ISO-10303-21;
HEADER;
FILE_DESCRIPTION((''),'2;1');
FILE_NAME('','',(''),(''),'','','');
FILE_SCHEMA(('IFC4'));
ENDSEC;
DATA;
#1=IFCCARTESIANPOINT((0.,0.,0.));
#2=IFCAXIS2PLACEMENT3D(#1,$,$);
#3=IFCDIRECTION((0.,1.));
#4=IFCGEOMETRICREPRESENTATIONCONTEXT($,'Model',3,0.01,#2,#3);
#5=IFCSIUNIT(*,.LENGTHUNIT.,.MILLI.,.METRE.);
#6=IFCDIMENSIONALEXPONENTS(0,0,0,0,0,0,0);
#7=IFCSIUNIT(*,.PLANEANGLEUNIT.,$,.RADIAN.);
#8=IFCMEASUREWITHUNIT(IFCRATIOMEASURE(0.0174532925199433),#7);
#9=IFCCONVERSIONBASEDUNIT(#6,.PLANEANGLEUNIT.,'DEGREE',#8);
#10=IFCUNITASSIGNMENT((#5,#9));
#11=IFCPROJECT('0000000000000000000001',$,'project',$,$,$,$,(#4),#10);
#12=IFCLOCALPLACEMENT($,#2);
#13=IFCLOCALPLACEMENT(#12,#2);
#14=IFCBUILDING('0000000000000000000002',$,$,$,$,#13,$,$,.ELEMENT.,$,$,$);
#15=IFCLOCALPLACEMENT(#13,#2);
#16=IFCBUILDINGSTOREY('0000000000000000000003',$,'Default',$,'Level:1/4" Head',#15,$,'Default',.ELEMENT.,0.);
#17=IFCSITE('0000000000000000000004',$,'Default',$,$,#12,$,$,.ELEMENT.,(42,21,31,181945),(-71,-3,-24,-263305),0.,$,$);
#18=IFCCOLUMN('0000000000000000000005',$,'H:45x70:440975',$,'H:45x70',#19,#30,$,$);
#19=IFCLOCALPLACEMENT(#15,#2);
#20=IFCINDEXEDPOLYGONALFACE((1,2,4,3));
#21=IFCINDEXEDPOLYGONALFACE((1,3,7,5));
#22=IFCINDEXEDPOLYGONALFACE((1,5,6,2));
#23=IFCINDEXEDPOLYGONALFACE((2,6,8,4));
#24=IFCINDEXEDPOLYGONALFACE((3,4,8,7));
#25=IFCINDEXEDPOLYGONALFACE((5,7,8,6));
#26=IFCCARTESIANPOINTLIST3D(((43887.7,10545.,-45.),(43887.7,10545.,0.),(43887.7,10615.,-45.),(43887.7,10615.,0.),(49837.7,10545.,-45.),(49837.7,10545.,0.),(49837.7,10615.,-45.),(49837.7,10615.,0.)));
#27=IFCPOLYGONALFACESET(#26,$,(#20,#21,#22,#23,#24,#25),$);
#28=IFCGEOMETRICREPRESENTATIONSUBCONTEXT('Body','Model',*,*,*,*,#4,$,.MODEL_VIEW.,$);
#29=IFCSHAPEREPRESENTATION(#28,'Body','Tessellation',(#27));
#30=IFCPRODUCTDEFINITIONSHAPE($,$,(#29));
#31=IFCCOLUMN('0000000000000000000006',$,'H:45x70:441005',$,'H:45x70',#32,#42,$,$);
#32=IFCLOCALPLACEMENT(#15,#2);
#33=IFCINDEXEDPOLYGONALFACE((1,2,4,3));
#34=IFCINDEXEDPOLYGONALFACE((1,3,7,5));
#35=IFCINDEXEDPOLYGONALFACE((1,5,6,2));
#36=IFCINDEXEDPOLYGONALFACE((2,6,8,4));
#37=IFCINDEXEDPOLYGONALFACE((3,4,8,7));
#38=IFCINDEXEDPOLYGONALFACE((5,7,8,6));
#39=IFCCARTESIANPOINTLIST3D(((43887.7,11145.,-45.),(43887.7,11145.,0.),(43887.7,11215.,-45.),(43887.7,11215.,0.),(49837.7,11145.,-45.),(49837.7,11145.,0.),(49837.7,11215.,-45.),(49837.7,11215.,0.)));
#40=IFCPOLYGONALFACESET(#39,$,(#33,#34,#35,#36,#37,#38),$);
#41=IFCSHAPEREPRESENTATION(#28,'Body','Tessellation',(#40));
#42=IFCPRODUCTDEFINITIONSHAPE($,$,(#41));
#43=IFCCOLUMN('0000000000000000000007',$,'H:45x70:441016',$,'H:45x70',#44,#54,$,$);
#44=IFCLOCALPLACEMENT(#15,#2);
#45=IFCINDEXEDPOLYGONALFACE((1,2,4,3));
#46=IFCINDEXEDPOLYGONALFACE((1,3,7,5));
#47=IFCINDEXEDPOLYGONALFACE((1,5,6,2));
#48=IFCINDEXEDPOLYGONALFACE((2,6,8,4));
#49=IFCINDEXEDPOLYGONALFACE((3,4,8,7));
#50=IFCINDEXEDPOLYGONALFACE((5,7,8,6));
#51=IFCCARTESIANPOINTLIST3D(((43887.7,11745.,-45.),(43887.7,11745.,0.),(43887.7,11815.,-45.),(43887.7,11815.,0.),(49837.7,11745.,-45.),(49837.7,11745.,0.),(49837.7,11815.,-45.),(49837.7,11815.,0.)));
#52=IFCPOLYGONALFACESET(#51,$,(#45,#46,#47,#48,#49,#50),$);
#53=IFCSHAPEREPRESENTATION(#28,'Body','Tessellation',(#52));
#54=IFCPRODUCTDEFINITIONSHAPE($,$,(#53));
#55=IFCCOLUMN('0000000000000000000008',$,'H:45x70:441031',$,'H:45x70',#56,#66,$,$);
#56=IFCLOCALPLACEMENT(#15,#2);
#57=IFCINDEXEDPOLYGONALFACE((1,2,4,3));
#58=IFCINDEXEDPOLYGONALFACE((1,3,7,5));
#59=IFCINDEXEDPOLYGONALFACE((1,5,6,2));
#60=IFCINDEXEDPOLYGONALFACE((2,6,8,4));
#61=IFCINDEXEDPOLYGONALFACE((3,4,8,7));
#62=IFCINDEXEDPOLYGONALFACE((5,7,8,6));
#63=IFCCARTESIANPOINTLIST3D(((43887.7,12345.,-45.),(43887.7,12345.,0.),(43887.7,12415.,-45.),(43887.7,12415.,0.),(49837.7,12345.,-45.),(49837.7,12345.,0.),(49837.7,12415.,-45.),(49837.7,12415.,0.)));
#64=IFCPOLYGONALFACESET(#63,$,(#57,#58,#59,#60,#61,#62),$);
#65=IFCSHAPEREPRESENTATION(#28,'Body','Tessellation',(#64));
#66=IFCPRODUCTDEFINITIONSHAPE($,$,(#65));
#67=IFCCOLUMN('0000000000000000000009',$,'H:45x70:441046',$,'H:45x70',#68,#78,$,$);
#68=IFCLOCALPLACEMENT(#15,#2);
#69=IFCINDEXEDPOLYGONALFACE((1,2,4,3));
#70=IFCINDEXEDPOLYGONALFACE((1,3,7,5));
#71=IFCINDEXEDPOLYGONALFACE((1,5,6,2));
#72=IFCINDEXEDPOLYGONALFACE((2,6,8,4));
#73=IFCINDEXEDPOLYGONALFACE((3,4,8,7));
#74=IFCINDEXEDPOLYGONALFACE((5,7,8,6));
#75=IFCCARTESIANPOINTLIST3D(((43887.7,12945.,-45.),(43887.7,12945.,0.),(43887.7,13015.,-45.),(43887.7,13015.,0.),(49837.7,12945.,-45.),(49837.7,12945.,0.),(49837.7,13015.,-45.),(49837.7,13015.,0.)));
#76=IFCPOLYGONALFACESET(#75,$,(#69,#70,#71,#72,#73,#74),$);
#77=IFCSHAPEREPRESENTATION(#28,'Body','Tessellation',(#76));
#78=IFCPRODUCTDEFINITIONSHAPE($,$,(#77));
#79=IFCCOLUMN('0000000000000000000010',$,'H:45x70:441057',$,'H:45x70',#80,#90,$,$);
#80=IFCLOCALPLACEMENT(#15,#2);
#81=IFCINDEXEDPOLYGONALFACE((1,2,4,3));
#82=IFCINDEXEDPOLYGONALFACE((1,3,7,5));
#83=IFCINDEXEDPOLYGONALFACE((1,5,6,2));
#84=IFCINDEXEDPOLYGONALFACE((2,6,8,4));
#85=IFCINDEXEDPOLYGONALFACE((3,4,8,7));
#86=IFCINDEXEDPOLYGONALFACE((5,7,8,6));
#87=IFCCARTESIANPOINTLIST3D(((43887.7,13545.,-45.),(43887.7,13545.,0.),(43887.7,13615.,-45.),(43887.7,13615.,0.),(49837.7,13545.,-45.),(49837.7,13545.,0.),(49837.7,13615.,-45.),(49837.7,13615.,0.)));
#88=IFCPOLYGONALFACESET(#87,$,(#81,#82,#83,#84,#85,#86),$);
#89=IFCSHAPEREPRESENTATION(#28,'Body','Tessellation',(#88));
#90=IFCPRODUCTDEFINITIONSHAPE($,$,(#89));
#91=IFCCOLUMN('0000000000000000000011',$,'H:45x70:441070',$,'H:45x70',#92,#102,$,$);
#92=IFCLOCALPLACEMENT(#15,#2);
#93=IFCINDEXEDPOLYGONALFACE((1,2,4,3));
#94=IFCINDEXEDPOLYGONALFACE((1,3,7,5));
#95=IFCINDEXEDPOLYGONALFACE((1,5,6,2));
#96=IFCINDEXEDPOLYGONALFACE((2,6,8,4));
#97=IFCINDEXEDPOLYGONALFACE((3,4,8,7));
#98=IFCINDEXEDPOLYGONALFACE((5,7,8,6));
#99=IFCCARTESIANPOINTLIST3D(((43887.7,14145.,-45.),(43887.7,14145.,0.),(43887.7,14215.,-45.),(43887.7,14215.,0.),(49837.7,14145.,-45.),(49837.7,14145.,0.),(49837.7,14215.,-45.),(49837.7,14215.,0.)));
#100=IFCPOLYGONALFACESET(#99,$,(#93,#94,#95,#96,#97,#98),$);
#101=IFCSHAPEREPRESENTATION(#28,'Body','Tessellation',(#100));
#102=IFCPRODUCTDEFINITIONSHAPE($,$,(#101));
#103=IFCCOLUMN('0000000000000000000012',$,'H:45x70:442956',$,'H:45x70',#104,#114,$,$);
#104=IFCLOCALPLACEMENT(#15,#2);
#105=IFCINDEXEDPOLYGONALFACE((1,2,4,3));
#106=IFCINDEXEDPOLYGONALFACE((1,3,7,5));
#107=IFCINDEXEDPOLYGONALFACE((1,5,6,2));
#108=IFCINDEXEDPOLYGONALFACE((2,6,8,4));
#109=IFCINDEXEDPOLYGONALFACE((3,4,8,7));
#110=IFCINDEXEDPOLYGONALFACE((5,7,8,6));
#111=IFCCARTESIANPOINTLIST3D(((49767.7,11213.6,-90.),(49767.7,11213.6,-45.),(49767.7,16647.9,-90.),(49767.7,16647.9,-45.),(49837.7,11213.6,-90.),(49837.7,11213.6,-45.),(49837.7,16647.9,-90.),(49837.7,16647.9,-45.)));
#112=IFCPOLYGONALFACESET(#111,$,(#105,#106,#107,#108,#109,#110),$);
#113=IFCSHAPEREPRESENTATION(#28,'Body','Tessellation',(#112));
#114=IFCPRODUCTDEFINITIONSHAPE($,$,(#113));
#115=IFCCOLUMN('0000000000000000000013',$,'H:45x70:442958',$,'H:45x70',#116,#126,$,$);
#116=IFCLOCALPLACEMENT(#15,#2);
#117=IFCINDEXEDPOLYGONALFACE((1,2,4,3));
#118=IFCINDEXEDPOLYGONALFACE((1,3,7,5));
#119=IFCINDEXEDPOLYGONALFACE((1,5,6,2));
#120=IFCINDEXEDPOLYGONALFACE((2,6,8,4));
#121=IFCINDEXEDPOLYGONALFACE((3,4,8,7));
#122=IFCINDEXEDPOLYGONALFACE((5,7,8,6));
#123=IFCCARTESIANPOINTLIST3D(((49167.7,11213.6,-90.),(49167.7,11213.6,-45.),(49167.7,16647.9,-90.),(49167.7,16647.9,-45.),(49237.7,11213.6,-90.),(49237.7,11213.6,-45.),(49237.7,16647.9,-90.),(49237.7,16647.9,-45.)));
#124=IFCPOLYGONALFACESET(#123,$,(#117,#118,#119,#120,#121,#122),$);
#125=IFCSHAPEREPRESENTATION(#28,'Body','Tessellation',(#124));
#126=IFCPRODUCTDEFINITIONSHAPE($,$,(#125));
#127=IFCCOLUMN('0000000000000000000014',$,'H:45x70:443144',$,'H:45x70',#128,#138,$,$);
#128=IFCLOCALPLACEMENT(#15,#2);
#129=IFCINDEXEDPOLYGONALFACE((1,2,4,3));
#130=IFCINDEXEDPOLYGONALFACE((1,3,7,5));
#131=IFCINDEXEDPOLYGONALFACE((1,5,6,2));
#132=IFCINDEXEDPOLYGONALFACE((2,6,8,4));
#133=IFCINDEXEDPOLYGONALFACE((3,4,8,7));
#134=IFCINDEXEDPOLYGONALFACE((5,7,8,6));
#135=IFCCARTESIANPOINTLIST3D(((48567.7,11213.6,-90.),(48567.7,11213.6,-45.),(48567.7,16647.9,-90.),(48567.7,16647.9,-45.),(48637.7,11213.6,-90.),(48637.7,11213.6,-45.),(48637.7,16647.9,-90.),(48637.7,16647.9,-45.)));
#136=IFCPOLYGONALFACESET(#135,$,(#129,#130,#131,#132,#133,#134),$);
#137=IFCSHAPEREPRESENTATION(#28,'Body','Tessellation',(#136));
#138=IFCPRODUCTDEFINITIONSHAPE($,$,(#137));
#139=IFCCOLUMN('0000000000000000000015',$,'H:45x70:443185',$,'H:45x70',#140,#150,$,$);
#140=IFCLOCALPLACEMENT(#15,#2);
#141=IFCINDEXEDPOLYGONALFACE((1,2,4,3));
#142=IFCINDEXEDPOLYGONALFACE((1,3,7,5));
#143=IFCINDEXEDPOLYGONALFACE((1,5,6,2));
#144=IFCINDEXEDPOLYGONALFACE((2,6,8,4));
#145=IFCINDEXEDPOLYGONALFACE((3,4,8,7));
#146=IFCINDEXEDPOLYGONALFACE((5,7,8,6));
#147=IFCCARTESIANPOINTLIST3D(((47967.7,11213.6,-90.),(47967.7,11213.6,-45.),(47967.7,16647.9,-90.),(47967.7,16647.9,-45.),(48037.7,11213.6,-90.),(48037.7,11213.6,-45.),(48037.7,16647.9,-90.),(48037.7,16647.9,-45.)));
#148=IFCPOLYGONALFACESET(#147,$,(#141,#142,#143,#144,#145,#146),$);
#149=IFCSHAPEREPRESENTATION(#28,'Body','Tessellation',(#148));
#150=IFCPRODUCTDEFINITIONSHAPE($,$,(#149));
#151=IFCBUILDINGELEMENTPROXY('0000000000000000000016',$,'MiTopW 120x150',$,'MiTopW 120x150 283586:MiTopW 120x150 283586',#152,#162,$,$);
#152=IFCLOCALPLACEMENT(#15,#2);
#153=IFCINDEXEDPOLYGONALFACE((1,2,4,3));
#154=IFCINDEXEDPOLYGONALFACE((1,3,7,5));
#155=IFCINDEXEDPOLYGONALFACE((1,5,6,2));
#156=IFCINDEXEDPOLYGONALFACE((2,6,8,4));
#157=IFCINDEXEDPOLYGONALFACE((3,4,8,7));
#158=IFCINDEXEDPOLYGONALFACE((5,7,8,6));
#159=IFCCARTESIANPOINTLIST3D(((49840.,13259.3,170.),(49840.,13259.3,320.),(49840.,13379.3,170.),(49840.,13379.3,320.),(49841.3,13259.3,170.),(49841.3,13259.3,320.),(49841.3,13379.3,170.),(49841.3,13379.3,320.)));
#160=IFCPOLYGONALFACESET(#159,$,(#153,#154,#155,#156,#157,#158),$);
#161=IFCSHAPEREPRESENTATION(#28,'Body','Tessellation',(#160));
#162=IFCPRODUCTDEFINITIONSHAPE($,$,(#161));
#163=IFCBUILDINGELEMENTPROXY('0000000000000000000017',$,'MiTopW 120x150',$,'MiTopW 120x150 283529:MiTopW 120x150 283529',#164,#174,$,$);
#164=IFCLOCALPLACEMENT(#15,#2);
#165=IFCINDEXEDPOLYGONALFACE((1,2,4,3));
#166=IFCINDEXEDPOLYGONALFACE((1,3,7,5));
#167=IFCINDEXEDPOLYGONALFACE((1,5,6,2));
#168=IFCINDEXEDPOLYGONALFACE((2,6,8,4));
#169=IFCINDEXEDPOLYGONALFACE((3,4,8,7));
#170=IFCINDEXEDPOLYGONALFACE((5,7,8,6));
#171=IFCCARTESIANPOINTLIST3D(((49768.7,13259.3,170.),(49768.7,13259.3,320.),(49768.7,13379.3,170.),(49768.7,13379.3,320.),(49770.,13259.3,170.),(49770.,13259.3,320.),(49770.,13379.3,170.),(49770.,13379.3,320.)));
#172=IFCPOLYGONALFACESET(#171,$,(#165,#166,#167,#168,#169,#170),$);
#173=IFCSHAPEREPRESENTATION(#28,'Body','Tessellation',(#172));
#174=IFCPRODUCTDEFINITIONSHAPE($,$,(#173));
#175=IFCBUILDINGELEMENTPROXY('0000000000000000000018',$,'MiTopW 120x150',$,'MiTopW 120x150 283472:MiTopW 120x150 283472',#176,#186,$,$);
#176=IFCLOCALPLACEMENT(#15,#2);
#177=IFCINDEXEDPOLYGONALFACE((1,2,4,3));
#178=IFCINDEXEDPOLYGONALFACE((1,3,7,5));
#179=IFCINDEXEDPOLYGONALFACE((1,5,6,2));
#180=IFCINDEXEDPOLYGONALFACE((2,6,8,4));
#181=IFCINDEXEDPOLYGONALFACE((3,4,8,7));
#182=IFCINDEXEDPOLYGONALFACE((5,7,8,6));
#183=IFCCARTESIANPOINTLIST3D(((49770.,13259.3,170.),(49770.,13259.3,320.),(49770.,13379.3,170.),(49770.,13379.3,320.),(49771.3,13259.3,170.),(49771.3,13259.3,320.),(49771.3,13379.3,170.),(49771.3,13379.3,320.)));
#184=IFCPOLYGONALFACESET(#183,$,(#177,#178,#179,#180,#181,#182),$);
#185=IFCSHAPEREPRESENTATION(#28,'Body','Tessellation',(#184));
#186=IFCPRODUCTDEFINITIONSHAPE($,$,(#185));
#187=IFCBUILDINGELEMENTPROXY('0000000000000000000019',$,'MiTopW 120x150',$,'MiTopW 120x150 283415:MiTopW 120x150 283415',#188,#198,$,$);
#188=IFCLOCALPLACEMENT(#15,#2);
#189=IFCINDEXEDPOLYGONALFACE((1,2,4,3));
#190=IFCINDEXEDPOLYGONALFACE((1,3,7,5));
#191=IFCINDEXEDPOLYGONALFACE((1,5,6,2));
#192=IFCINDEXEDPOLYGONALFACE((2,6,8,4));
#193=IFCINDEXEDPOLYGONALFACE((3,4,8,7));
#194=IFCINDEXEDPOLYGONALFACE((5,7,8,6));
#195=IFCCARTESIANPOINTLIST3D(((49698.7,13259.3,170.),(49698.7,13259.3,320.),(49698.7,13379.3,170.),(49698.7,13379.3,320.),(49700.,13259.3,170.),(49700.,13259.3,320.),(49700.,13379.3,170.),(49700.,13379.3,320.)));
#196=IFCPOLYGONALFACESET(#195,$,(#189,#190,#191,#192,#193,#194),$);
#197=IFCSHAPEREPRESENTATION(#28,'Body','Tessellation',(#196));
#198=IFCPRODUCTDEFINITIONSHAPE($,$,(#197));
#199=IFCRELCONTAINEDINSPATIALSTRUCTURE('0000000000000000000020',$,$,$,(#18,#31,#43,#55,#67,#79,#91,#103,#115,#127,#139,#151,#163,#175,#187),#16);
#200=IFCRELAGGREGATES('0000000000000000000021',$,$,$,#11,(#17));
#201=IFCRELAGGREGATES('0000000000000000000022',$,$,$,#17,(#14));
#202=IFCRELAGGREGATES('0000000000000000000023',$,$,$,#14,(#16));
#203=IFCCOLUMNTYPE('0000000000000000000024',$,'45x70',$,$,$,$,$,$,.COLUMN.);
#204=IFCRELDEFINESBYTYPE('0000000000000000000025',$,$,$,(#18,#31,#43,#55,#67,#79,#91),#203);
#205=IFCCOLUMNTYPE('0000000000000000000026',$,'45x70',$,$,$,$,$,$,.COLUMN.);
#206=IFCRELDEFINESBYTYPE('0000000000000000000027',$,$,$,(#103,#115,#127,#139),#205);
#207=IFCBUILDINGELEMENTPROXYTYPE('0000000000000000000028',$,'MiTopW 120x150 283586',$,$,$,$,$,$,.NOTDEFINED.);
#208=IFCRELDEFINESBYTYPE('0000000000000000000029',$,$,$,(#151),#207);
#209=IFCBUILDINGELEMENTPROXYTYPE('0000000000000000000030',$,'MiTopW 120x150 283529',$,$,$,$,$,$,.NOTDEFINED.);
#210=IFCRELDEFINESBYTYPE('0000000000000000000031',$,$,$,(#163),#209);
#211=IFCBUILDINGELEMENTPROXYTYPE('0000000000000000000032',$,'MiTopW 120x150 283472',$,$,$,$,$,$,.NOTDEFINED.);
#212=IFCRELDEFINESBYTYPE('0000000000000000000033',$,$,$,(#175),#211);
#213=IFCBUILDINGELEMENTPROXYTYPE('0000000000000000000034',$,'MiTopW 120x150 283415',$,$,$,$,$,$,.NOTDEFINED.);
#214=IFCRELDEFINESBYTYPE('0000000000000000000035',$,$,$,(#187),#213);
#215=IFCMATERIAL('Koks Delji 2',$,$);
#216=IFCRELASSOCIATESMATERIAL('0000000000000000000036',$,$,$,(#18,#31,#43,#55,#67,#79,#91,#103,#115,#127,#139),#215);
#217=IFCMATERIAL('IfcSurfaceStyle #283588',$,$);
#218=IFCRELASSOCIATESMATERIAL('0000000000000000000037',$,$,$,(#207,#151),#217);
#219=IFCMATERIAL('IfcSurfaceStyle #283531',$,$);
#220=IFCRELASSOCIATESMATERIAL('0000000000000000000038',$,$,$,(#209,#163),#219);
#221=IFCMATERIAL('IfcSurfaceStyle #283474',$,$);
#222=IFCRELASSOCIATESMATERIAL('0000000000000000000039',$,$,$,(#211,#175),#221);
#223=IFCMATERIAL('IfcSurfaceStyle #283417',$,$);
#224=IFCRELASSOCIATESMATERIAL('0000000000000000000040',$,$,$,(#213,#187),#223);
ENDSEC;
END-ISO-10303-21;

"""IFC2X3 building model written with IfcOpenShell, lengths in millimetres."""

from ifc_helpers import new_model, entity, si_unit, converted_unit, direction, frame, frame_2d, origin, origin_2d_with_axis, place, context, subcontext, project, spatial, rectangle, extrude, source, transform, mapped, material, type_object, type_shapes, element, save


model = new_model("IFC2X3")

# Units and contexts
model_context = context("Model", 3, precision=0.01, world=origin(), true_north=direction((0.0, 1.0)))
body_context = subcontext(model_context, "Body", "Model", "MODEL_VIEW")
ifc_project = project(units=[si_unit("LENGTHUNIT", "METRE", prefix="MILLI"), converted_unit("PLANEANGLEUNIT", "DEGREE", entity("IfcRatioMeasure", 0.0174532925199433), si_unit("PLANEANGLEUNIT", "RADIAN"), dimensions=[0, 0, 0, 0, 0, 0, 0])], contexts=[model_context])

# Site, building, storey
site_placement = place(None, origin())
site = spatial("IfcSite", under=ifc_project, at=site_placement, Name="Default", CompositionType="ELEMENT", RefLatitude=(42, 21, 31, 181945), RefLongitude=(-71, -3, -24, -263305), RefElevation=0.0)
building_placement = place(site_placement, origin())
building = spatial("IfcBuilding", under=site, at=building_placement, CompositionType="ELEMENT")
storey_placement = place(building_placement, origin())
storey = spatial("IfcBuildingStorey", under=building, at=storey_placement, Name="Default", ObjectType="Level:1/4\" Head", LongName="Default", CompositionType="ELEMENT", Elevation=0.0)

# Columns
ifc_material_1 = material(Name="Koks Delji 2")
column_type_1 = type_object("IfcColumnType", Name="45x70", PredefinedType="COLUMN")
shared_shape_1 = source(origin(), body_context, "Body", "SweptSolid", [
    extrude(rectangle(XDim=70.0, YDim=5950.0, at=frame_2d((0.0, 0.0), x_axis=(1.0, 0.0))), frame((2975.0, 237.8, 0.0), z_axis=(0.0, 0.0, 1.0), x_axis=(0.0, -1.0, 0.0)), (0.0, 0.0, 1.0), 45.0),
])
type_shapes(column_type_1, [shared_shape_1])
for number, where, z_axis, x_axis, name in (
    (1, (49837.7, 10817.8, -45.0), (0.0, 0.0, 1.0), (-1.0, 0.0, 0.0), "H:45x70:440975"),
    (2, (49837.7, 11417.8, -45.0), (0.0, 0.0, 1.0), (-1.0, 0.0, 0.0), "H:45x70:441005"),
    (3, (49837.7, 12017.8, -45.0), (0.0, 0.0, 1.0), (-1.0, 0.0, 0.0), "H:45x70:441016"),
    (4, (49837.7, 12617.8, -45.0), (0.0, 0.0, 1.0), (-1.0, 0.0, 0.0), "H:45x70:441031"),
    (5, (49837.7, 13217.8, -45.0), (0.0, 0.0, 1.0), (-1.0, 0.0, 0.0), "H:45x70:441046"),
    (6, (49837.7, 13817.8, -45.0), (0.0, 0.0, 1.0), (-1.0, 0.0, 0.0), "H:45x70:441057"),
    (7, (49837.7, 14417.8, -45.0), (0.0, 0.0, 1.0), (-1.0, 0.0, 0.0), "H:45x70:441070"),
):
    element("IfcColumn", number, at=place(storey_placement, frame(where, z_axis=z_axis, x_axis=x_axis)), inside=storey, type_object=column_type_1, material=ifc_material_1, Name=name, ObjectType="H:45x70", context=body_context, shape_type="MappedRepresentation", body=[
        mapped(shared_shape_1, transform((0.0, 0.0, 0.0), scale=1.0)),
    ])
column_type_2 = type_object("IfcColumnType", Name="45x70", PredefinedType="COLUMN")
shared_shape_2 = source(origin(), body_context, "Body", "SweptSolid", [
    extrude(rectangle(XDim=70.0, YDim=5434.3, at=frame_2d((0.0, 0.0), x_axis=(1.0, 0.0))), frame((2717.1, 237.8, 0.0), z_axis=(0.0, 0.0, 1.0), x_axis=(0.0, -1.0, 0.0)), (0.0, 0.0, 1.0), 45.0),
])
type_shapes(column_type_2, [shared_shape_2])
for number, where, z_axis, x_axis, name in (
    (8, (50040.6, 11213.6, -90.0), (0.0, 0.0, 1.0), (0.0, 1.0, 0.0), "H:45x70:442956"),
    (9, (49440.6, 11213.6, -90.0), (0.0, 0.0, 1.0), (0.0, 1.0, 0.0), "H:45x70:442958"),
    (10, (48840.6, 11213.6, -90.0), (0.0, 0.0, 1.0), (0.0, 1.0, 0.0), "H:45x70:443144"),
    (11, (48240.6, 11213.6, -90.0), (0.0, 0.0, 1.0), (0.0, 1.0, 0.0), "H:45x70:443185"),
):
    element("IfcColumn", number, at=place(storey_placement, frame(where, z_axis=z_axis, x_axis=x_axis)), inside=storey, type_object=column_type_2, material=ifc_material_1, Name=name, ObjectType="H:45x70", context=body_context, shape_type="MappedRepresentation", body=[
        mapped(shared_shape_2, transform((0.0, 0.0, 0.0), scale=1.0)),
    ])

# Building element proxies
ifc_material_2 = material(Name="IfcSurfaceStyle #283588")
building_element_proxy_type_1 = type_object("IfcBuildingElementProxyType", Name="MiTopW 120x150 283586", PredefinedType="NOTDEFINED", material=ifc_material_2)
shared_shape_3 = source(origin(), body_context, "Body", "SweptSolid", [
    extrude(rectangle(XDim=150.0, YDim=120.0, at=origin_2d_with_axis()), frame((75.0, 60.0, 0.0), z_axis=(0.0, 0.0, 1.0), x_axis=(-1.0, 0.0, 0.0)), (0.0, 0.0, 1.0), 1.3),
])
type_shapes(building_element_proxy_type_1, [shared_shape_3])
proxy_1_placement = place(building_placement, frame((49841.3, 13259.3, 170.0), z_axis=(-1.0, 0.0, 0.0), x_axis=(0.0, 0.0, 1.0)))
element("IfcBuildingElementProxy", 12, at=proxy_1_placement, inside=storey, type_object=building_element_proxy_type_1, material=ifc_material_2, Name="MiTopW 120x150", ObjectType="MiTopW 120x150 283586:MiTopW 120x150 283586", context=body_context, shape_type="MappedRepresentation", body=[
    mapped(shared_shape_3, transform((0.0, 0.0, 0.0), scale=1.0)),
])
ifc_material_3 = material(Name="IfcSurfaceStyle #283531")
building_element_proxy_type_2 = type_object("IfcBuildingElementProxyType", Name="MiTopW 120x150 283529", PredefinedType="NOTDEFINED", material=ifc_material_3)
shared_shape_4 = source(origin(), body_context, "Body", "SweptSolid", [
    extrude(rectangle(XDim=150.0, YDim=120.0, at=origin_2d_with_axis()), frame((75.0, 60.0, 0.0), z_axis=(0.0, 0.0, 1.0), x_axis=(-1.0, 0.0, 0.0)), (0.0, 0.0, 1.0), 1.3),
])
type_shapes(building_element_proxy_type_2, [shared_shape_4])
proxy_2_placement = place(building_placement, frame((49770.0, 13259.3, 170.0), z_axis=(-1.0, 0.0, 0.0), x_axis=(0.0, 0.0, 1.0)))
element("IfcBuildingElementProxy", 13, at=proxy_2_placement, inside=storey, type_object=building_element_proxy_type_2, material=ifc_material_3, Name="MiTopW 120x150", ObjectType="MiTopW 120x150 283529:MiTopW 120x150 283529", context=body_context, shape_type="MappedRepresentation", body=[
    mapped(shared_shape_4, transform((0.0, 0.0, 0.0), scale=1.0)),
])
ifc_material_4 = material(Name="IfcSurfaceStyle #283474")
building_element_proxy_type_3 = type_object("IfcBuildingElementProxyType", Name="MiTopW 120x150 283472", PredefinedType="NOTDEFINED", material=ifc_material_4)
shared_shape_5 = source(origin(), body_context, "Body", "SweptSolid", [
    extrude(rectangle(XDim=150.0, YDim=120.0, at=origin_2d_with_axis()), frame((75.0, 60.0, 0.0), z_axis=(0.0, 0.0, 1.0), x_axis=(-1.0, 0.0, 0.0)), (0.0, 0.0, 1.0), 1.3),
])
type_shapes(building_element_proxy_type_3, [shared_shape_5])
proxy_3_placement = place(building_placement, frame((49771.3, 13259.3, 170.0), z_axis=(-1.0, 0.0, 0.0), x_axis=(0.0, 0.0, 1.0)))
element("IfcBuildingElementProxy", 14, at=proxy_3_placement, inside=storey, type_object=building_element_proxy_type_3, material=ifc_material_4, Name="MiTopW 120x150", ObjectType="MiTopW 120x150 283472:MiTopW 120x150 283472", context=body_context, shape_type="MappedRepresentation", body=[
    mapped(shared_shape_5, transform((0.0, 0.0, 0.0), scale=1.0)),
])
ifc_material_5 = material(Name="IfcSurfaceStyle #283417")
building_element_proxy_type_4 = type_object("IfcBuildingElementProxyType", Name="MiTopW 120x150 283415", PredefinedType="NOTDEFINED", material=ifc_material_5)
shared_shape_6 = source(origin(), body_context, "Body", "SweptSolid", [
    extrude(rectangle(XDim=150.0, YDim=120.0, at=origin_2d_with_axis()), frame((75.0, 60.0, 0.0), z_axis=(0.0, 0.0, 1.0), x_axis=(-1.0, 0.0, 0.0)), (0.0, 0.0, 1.0), 1.3),
])
type_shapes(building_element_proxy_type_4, [shared_shape_6])
proxy_4_placement = place(building_placement, frame((49700.0, 13259.3, 170.0), z_axis=(-1.0, 0.0, 0.0), x_axis=(0.0, 0.0, 1.0)))
element("IfcBuildingElementProxy", 15, at=proxy_4_placement, inside=storey, type_object=building_element_proxy_type_4, material=ifc_material_5, Name="MiTopW 120x150", ObjectType="MiTopW 120x150 283415:MiTopW 120x150 283415", context=body_context, shape_type="MappedRepresentation", body=[
    mapped(shared_shape_6, transform((0.0, 0.0, 0.0), scale=1.0)),
])

save(model, "model.ifc")
